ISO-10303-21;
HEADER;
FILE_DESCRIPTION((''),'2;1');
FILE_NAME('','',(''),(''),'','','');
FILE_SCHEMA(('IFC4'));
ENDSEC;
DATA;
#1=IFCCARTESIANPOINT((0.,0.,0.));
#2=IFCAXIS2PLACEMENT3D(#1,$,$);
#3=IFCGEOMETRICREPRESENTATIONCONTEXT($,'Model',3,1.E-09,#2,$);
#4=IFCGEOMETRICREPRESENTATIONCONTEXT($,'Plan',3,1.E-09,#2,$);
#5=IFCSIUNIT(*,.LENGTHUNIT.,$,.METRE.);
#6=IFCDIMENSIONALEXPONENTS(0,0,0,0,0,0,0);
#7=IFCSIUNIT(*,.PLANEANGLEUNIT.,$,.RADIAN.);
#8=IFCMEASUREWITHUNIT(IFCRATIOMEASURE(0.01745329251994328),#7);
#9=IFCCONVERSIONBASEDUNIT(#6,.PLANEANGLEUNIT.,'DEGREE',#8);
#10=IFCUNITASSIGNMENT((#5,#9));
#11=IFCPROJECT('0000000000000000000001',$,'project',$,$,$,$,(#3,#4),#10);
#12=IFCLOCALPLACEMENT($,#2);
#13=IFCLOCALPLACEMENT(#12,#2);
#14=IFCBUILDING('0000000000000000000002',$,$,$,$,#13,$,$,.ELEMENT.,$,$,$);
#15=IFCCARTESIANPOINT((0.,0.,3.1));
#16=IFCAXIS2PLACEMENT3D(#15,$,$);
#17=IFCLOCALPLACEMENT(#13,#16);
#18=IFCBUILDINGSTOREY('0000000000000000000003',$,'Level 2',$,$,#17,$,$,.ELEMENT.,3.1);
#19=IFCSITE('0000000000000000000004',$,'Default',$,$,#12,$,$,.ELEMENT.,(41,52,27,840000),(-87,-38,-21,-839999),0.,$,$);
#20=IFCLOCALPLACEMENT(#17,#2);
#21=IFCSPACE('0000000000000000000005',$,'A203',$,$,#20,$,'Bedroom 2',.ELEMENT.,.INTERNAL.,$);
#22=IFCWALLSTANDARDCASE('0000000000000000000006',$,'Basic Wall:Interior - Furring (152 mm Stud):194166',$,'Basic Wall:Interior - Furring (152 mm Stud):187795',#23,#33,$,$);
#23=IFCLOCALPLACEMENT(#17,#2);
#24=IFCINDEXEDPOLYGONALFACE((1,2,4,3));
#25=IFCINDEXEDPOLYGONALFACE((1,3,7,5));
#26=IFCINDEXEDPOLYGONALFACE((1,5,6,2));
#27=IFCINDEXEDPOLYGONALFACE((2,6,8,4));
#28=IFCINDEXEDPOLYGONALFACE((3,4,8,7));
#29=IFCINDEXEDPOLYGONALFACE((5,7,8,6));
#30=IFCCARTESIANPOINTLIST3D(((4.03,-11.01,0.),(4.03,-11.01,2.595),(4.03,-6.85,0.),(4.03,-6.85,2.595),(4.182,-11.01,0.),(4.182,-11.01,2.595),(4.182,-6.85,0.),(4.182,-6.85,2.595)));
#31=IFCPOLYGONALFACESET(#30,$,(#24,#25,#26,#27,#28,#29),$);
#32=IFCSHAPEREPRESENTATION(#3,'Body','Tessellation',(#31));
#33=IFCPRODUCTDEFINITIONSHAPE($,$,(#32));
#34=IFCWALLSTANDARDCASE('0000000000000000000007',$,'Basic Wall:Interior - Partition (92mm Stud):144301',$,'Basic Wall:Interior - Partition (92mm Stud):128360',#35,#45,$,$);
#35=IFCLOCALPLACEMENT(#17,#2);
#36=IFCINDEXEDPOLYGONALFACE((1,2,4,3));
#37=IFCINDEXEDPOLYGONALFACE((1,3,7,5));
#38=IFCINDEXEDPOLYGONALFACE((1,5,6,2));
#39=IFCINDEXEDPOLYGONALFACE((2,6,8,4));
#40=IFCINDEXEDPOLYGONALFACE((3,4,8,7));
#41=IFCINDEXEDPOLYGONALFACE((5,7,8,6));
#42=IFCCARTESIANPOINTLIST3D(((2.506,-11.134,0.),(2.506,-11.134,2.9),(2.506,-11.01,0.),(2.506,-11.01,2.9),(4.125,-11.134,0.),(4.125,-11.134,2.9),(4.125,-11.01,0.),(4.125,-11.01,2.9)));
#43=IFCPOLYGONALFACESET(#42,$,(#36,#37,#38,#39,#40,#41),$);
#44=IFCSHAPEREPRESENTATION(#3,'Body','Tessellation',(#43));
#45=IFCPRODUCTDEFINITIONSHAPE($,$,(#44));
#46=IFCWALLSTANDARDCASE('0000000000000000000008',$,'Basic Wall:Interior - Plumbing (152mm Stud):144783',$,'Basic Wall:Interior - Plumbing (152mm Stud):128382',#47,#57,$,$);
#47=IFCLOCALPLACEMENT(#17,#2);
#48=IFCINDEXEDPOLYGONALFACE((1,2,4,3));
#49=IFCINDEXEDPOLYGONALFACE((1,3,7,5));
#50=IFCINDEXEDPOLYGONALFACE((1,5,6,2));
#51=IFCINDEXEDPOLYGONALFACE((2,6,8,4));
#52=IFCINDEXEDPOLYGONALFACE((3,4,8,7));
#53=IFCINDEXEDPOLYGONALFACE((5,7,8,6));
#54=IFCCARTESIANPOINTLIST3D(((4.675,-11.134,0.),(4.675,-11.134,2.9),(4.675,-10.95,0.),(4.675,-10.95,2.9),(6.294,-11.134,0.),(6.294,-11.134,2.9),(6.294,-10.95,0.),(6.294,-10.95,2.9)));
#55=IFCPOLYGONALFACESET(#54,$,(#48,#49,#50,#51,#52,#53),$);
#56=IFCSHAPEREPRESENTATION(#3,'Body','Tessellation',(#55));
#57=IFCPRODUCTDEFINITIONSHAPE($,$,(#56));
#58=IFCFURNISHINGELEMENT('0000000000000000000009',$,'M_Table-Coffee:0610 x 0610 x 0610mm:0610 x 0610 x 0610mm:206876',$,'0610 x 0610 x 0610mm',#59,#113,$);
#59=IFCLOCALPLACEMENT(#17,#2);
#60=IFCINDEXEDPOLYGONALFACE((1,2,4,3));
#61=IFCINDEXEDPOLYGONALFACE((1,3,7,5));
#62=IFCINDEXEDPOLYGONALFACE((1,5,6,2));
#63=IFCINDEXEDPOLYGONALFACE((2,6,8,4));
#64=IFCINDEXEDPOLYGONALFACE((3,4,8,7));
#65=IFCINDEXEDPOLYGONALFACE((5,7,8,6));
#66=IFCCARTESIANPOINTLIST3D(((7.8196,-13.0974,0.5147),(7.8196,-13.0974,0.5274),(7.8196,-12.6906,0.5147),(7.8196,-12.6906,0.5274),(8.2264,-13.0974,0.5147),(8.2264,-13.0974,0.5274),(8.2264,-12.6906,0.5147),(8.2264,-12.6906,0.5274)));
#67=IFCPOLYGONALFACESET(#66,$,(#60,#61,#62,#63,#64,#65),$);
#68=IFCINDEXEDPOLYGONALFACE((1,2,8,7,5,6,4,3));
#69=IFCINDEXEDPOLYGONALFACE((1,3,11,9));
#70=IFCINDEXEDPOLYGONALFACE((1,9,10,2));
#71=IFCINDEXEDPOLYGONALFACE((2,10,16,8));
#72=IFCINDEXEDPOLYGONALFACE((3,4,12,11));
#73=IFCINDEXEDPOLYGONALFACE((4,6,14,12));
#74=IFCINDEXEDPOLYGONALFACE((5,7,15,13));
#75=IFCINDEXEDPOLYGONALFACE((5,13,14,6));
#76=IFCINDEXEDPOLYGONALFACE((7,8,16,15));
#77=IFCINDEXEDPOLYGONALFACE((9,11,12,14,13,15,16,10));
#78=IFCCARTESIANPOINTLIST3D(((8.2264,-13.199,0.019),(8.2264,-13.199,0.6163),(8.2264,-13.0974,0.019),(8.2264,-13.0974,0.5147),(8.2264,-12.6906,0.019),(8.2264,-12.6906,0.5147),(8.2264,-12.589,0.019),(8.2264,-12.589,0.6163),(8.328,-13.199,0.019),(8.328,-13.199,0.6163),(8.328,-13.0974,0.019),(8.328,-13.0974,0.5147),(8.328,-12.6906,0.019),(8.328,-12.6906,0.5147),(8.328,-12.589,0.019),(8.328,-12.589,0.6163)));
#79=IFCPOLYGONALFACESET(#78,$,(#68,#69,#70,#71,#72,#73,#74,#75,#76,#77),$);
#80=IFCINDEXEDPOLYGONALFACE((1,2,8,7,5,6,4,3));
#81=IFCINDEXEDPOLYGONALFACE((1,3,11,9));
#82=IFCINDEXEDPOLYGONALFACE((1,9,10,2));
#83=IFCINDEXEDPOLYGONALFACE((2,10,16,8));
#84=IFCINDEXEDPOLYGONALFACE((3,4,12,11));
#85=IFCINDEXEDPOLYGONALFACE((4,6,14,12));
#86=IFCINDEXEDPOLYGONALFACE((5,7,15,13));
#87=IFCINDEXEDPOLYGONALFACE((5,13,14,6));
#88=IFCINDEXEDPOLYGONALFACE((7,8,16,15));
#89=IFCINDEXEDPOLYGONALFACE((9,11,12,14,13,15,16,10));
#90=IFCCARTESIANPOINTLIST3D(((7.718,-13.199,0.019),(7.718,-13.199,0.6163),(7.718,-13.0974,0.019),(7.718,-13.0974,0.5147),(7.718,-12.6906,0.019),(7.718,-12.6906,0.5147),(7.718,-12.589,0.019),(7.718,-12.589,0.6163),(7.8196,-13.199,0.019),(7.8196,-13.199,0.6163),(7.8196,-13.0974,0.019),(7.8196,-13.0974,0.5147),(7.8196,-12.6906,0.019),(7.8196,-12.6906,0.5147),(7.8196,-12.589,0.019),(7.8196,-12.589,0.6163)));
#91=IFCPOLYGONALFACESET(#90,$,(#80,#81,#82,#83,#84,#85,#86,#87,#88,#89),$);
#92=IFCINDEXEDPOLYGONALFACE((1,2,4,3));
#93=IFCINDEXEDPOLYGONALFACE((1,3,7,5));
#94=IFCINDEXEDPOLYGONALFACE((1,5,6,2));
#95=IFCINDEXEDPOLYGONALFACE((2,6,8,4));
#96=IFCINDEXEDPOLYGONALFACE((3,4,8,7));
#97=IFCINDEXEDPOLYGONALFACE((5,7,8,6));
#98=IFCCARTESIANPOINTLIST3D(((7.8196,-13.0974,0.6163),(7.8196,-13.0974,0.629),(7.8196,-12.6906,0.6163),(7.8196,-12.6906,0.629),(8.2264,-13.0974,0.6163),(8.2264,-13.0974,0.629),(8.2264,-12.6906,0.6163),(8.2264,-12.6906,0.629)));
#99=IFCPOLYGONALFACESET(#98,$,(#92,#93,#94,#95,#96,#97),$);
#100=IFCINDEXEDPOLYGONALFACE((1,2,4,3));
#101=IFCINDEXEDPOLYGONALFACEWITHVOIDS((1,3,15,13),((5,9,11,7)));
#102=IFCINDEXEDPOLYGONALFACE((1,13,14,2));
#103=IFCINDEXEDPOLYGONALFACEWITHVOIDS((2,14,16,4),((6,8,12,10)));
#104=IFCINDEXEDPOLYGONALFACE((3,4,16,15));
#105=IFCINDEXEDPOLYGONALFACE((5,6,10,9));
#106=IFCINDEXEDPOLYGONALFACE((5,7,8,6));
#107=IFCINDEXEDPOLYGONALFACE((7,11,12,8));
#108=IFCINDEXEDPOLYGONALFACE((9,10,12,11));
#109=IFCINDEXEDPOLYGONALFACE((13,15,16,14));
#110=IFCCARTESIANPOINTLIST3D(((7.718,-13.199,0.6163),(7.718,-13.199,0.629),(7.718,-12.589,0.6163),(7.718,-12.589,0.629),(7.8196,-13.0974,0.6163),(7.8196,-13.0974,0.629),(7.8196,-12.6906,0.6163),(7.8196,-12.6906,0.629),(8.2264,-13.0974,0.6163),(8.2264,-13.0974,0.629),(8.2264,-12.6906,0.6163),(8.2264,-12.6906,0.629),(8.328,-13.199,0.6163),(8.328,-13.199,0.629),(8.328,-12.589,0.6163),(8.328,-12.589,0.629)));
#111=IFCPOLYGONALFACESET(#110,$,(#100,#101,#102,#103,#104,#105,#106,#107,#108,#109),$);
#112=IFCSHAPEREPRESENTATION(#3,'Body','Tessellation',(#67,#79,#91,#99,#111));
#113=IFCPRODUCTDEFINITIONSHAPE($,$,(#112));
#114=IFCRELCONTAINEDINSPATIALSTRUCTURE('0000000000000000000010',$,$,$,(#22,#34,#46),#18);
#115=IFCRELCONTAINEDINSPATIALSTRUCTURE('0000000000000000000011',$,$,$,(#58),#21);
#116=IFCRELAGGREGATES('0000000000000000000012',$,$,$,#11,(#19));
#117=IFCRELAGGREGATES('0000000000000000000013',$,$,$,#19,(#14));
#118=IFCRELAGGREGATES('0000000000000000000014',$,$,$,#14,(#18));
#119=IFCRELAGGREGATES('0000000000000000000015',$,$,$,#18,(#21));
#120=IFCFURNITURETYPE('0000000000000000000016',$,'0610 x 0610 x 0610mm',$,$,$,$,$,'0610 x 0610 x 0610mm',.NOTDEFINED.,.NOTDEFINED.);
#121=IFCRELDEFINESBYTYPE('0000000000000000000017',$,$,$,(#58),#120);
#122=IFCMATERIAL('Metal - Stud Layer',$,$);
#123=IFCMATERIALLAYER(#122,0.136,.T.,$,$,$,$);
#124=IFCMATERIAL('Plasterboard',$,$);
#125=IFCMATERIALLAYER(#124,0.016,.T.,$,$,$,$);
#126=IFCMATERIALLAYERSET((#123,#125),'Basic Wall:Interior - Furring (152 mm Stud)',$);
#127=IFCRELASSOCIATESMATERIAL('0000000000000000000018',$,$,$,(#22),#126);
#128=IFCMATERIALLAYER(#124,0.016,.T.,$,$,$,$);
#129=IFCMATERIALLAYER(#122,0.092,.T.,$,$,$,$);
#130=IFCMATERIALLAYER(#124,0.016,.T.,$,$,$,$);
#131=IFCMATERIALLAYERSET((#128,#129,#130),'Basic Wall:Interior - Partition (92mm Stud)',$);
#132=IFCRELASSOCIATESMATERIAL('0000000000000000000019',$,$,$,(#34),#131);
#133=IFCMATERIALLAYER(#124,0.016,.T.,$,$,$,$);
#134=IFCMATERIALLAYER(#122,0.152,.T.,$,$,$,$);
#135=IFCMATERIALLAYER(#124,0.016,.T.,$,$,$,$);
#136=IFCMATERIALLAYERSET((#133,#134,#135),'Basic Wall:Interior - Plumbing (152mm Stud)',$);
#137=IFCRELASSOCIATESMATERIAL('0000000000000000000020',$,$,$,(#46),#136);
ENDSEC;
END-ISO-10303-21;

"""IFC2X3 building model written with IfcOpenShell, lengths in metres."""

from ifc_helpers import new_model, entity, si_unit, converted_unit, frame, frame_2d, origin, origin_2d_with_axis, place, context, project, spatial, polyline, rectangle, outline, extrude, source, transform, mapped, material, layer, layer_set, layer_usage, type_object, type_shapes, element, save


model = new_model("IFC2X3")

# Units and contexts
model_context = context("Model", 3, precision=1e-09, world=origin())
plan_context = context("Plan", 3, precision=1e-09, world=origin())
ifc_project = project(units=[si_unit("LENGTHUNIT", "METRE"), converted_unit("PLANEANGLEUNIT", "DEGREE", entity("IfcRatioMeasure", 0.01745329251994328), si_unit("PLANEANGLEUNIT", "RADIAN"), dimensions=[0, 0, 0, 0, 0, 0, 0])], contexts=[model_context, plan_context])

# Site, building, storey
site_placement = place(None, origin())
site = spatial("IfcSite", under=ifc_project, at=site_placement, Name="Default", CompositionType="ELEMENT", RefLatitude=(41, 52, 27, 840000), RefLongitude=(-87, -38, -21, -839999), RefElevation=0.0)
building_placement = place(site_placement, origin())
building = spatial("IfcBuilding", under=site, at=building_placement, CompositionType="ELEMENT")
storey_placement = place(building_placement, frame((0.0, 0.0, 3.1)))
storey = spatial("IfcBuildingStorey", under=building, at=storey_placement, Name="Level 2", CompositionType="ELEMENT", Elevation=3.1)

# Shared definitions
ifc_material_1 = material(Name="Metal - Stud Layer")
ifc_material_2 = material(Name="Plasterboard")

# Shared definitions
ifc_layer_1 = layer(ifc_material_2, 0.016, ventilated=True)
ifc_layer_2 = layer(ifc_material_1, 0.092, ventilated=True)
ifc_layer_3 = layer(ifc_material_2, 0.016, ventilated=True)
ifc_layer_set_1 = layer_set([ifc_layer_1, ifc_layer_2, ifc_layer_3], Name="Basic Wall:Interior - Partition (92mm Stud)")
ifc_layer_usage_1 = layer_usage(ifc_layer_set_1, "AXIS2", "NEGATIVE", 0.062)

# Walls
ifc_layer_4 = layer(ifc_material_1, 0.136, ventilated=True)
ifc_layer_5 = layer(ifc_material_2, 0.016, ventilated=True)
ifc_layer_set_2 = layer_set([ifc_layer_4, ifc_layer_5], Name="Basic Wall:Interior - Furring (152 mm Stud)")
ifc_layer_usage_2 = layer_usage(ifc_layer_set_2, "AXIS2", "POSITIVE", -0.076)
wall_1_placement = place(storey_placement, frame((4.106, -11.01, 0.0), z_axis=(0.0, 0.0, 1.0), x_axis=(0.0, 1.0, 0.0)))
element("IfcWallStandardCase", 1, at=wall_1_placement, inside=storey, material=ifc_layer_usage_2, Name="Basic Wall:Interior - Furring (152 mm Stud):194166", ObjectType="Basic Wall:Interior - Furring (152 mm Stud):187795", context=model_context, shape_type="SweptSolid", body=[
    extrude(rectangle(XDim=4.16, YDim=0.152, at=frame_2d((2.08, 0.0), x_axis=(-1.0, 0.0))), origin(), (0.0, 0.0, 1.0), 2.595),
])
wall_2_placement = place(storey_placement, frame((4.125, -11.072, 0.0), z_axis=(0.0, 0.0, 1.0), x_axis=(-1.0, 0.0, 0.0)))
element("IfcWallStandardCase", 2, at=wall_2_placement, inside=storey, material=ifc_layer_usage_1, Name="Basic Wall:Interior - Partition (92mm Stud):144301", ObjectType="Basic Wall:Interior - Partition (92mm Stud):128360", context=model_context, shape_type="SweptSolid", body=[
    extrude(rectangle(XDim=1.619, YDim=0.124, at=frame_2d((0.8095, 0.0), x_axis=(-1.0, 0.0))), origin(), (0.0, 0.0, 1.0), 2.9),
])
ifc_layer_6 = layer(ifc_material_2, 0.016, ventilated=True)
ifc_layer_7 = layer(ifc_material_1, 0.152, ventilated=True)
ifc_layer_8 = layer(ifc_material_2, 0.016, ventilated=True)
ifc_layer_set_3 = layer_set([ifc_layer_6, ifc_layer_7, ifc_layer_8], Name="Basic Wall:Interior - Plumbing (152mm Stud)")
ifc_layer_usage_3 = layer_usage(ifc_layer_set_3, "AXIS2", "NEGATIVE", 0.092)
wall_3_placement = place(storey_placement, frame((6.294, -11.042, 0.0), z_axis=(0.0, 0.0, 1.0), x_axis=(-1.0, 0.0, 0.0)))
element("IfcWallStandardCase", 3, at=wall_3_placement, inside=storey, material=ifc_layer_usage_3, Name="Basic Wall:Interior - Plumbing (152mm Stud):144783", ObjectType="Basic Wall:Interior - Plumbing (152mm Stud):128382", context=model_context, shape_type="SweptSolid", body=[
    extrude(rectangle(XDim=1.619, YDim=0.184, at=frame_2d((0.8095, 0.0), x_axis=(-1.0, 0.0))), origin(), (0.0, 0.0, 1.0), 2.9),
])

# Shared definitions
space_placement = place(storey_placement, origin())
space = spatial("IfcSpace", under=storey, at=space_placement, Name="A203", LongName="Bedroom 2", CompositionType="ELEMENT", InteriorOrExteriorSpace="INTERNAL")

# Furnishing element
furniture_type = type_object("IfcFurnitureType", Name="0610 x 0610 x 0610mm", ElementType="0610 x 0610 x 0610mm", AssemblyPlace="NOTDEFINED")
shared_shape_1 = source(origin(), model_context, "Body", "SweptSolid", [
    extrude(rectangle(XDim=0.4068, YDim=0.4068, at=origin_2d_with_axis()), frame((0.0183, 0.0952, 0.4957), z_axis=(0.0, 0.0, 1.0), x_axis=(-1.0, 0.0, 0.0)), (0.0, 0.0, 1.0), 0.0127),
    extrude(outline(polyline([(-0.2732, -0.305), (0.324, -0.305), (0.324, 0.305), (-0.2732, 0.305), (-0.2732, 0.2034), (0.2225, 0.2034), (0.2225, -0.2034), (-0.2732, -0.2034), (-0.2732, -0.305)])), frame((0.2217, 0.0952, 0.2732), z_axis=(1.0, 0.0, 0.0), x_axis=(0.0, 0.0, 1.0)), (0.0, 0.0, 1.0), 0.1016),
    extrude(outline(polyline([(-0.305, -0.3241), (0.305, -0.3241), (0.305, 0.2733), (0.2034, 0.2733), (0.2034, -0.2224), (-0.2034, -0.2224), (-0.2034, 0.2733), (-0.305, 0.2733), (-0.305, -0.3241)])), frame((-0.2867, 0.0952, 0.2733), z_axis=(1.0, 0.0, 0.0), x_axis=(0.0, -1.0, 0.0)), (0.0, 0.0, 1.0), 0.1016),
    extrude(rectangle(XDim=0.4068, YDim=0.4068, at=origin_2d_with_axis()), frame((0.0183, 0.0952, 0.5973), z_axis=(0.0, 0.0, 1.0), x_axis=(-1.0, 0.0, 0.0)), (0.0, 0.0, 1.0), 0.0127),
    extrude(outline(polyline([(-0.305, -0.305), (0.305, -0.305), (0.305, 0.305), (-0.305, 0.305), (-0.305, -0.305)]), holes=[polyline([(-0.2034, -0.2034), (-0.2034, 0.2034), (0.2034, 0.2034), (0.2034, -0.2034), (-0.2034, -0.2034)])]), frame((0.0183, 0.0952, 0.5973), z_axis=(0.0, 0.0, 1.0), x_axis=(-1.0, 0.0, 0.0)), (0.0, 0.0, 1.0), 0.0127),
])
type_shapes(furniture_type, [shared_shape_1])
furnishing_placement = place(space_placement, frame((8.0047, -12.9892, 0.019)))
element("IfcFurnishingElement", 4, at=furnishing_placement, inside=space, type_object=furniture_type, Name="M_Table-Coffee:0610 x 0610 x 0610mm:0610 x 0610 x 0610mm:206876", ObjectType="0610 x 0610 x 0610mm", context=model_context, shape_type="MappedRepresentation", body=[
    mapped(shared_shape_1, transform((0.0, 0.0, 0.0), scale=1.0)),
])

save(model, "model.ifc")
